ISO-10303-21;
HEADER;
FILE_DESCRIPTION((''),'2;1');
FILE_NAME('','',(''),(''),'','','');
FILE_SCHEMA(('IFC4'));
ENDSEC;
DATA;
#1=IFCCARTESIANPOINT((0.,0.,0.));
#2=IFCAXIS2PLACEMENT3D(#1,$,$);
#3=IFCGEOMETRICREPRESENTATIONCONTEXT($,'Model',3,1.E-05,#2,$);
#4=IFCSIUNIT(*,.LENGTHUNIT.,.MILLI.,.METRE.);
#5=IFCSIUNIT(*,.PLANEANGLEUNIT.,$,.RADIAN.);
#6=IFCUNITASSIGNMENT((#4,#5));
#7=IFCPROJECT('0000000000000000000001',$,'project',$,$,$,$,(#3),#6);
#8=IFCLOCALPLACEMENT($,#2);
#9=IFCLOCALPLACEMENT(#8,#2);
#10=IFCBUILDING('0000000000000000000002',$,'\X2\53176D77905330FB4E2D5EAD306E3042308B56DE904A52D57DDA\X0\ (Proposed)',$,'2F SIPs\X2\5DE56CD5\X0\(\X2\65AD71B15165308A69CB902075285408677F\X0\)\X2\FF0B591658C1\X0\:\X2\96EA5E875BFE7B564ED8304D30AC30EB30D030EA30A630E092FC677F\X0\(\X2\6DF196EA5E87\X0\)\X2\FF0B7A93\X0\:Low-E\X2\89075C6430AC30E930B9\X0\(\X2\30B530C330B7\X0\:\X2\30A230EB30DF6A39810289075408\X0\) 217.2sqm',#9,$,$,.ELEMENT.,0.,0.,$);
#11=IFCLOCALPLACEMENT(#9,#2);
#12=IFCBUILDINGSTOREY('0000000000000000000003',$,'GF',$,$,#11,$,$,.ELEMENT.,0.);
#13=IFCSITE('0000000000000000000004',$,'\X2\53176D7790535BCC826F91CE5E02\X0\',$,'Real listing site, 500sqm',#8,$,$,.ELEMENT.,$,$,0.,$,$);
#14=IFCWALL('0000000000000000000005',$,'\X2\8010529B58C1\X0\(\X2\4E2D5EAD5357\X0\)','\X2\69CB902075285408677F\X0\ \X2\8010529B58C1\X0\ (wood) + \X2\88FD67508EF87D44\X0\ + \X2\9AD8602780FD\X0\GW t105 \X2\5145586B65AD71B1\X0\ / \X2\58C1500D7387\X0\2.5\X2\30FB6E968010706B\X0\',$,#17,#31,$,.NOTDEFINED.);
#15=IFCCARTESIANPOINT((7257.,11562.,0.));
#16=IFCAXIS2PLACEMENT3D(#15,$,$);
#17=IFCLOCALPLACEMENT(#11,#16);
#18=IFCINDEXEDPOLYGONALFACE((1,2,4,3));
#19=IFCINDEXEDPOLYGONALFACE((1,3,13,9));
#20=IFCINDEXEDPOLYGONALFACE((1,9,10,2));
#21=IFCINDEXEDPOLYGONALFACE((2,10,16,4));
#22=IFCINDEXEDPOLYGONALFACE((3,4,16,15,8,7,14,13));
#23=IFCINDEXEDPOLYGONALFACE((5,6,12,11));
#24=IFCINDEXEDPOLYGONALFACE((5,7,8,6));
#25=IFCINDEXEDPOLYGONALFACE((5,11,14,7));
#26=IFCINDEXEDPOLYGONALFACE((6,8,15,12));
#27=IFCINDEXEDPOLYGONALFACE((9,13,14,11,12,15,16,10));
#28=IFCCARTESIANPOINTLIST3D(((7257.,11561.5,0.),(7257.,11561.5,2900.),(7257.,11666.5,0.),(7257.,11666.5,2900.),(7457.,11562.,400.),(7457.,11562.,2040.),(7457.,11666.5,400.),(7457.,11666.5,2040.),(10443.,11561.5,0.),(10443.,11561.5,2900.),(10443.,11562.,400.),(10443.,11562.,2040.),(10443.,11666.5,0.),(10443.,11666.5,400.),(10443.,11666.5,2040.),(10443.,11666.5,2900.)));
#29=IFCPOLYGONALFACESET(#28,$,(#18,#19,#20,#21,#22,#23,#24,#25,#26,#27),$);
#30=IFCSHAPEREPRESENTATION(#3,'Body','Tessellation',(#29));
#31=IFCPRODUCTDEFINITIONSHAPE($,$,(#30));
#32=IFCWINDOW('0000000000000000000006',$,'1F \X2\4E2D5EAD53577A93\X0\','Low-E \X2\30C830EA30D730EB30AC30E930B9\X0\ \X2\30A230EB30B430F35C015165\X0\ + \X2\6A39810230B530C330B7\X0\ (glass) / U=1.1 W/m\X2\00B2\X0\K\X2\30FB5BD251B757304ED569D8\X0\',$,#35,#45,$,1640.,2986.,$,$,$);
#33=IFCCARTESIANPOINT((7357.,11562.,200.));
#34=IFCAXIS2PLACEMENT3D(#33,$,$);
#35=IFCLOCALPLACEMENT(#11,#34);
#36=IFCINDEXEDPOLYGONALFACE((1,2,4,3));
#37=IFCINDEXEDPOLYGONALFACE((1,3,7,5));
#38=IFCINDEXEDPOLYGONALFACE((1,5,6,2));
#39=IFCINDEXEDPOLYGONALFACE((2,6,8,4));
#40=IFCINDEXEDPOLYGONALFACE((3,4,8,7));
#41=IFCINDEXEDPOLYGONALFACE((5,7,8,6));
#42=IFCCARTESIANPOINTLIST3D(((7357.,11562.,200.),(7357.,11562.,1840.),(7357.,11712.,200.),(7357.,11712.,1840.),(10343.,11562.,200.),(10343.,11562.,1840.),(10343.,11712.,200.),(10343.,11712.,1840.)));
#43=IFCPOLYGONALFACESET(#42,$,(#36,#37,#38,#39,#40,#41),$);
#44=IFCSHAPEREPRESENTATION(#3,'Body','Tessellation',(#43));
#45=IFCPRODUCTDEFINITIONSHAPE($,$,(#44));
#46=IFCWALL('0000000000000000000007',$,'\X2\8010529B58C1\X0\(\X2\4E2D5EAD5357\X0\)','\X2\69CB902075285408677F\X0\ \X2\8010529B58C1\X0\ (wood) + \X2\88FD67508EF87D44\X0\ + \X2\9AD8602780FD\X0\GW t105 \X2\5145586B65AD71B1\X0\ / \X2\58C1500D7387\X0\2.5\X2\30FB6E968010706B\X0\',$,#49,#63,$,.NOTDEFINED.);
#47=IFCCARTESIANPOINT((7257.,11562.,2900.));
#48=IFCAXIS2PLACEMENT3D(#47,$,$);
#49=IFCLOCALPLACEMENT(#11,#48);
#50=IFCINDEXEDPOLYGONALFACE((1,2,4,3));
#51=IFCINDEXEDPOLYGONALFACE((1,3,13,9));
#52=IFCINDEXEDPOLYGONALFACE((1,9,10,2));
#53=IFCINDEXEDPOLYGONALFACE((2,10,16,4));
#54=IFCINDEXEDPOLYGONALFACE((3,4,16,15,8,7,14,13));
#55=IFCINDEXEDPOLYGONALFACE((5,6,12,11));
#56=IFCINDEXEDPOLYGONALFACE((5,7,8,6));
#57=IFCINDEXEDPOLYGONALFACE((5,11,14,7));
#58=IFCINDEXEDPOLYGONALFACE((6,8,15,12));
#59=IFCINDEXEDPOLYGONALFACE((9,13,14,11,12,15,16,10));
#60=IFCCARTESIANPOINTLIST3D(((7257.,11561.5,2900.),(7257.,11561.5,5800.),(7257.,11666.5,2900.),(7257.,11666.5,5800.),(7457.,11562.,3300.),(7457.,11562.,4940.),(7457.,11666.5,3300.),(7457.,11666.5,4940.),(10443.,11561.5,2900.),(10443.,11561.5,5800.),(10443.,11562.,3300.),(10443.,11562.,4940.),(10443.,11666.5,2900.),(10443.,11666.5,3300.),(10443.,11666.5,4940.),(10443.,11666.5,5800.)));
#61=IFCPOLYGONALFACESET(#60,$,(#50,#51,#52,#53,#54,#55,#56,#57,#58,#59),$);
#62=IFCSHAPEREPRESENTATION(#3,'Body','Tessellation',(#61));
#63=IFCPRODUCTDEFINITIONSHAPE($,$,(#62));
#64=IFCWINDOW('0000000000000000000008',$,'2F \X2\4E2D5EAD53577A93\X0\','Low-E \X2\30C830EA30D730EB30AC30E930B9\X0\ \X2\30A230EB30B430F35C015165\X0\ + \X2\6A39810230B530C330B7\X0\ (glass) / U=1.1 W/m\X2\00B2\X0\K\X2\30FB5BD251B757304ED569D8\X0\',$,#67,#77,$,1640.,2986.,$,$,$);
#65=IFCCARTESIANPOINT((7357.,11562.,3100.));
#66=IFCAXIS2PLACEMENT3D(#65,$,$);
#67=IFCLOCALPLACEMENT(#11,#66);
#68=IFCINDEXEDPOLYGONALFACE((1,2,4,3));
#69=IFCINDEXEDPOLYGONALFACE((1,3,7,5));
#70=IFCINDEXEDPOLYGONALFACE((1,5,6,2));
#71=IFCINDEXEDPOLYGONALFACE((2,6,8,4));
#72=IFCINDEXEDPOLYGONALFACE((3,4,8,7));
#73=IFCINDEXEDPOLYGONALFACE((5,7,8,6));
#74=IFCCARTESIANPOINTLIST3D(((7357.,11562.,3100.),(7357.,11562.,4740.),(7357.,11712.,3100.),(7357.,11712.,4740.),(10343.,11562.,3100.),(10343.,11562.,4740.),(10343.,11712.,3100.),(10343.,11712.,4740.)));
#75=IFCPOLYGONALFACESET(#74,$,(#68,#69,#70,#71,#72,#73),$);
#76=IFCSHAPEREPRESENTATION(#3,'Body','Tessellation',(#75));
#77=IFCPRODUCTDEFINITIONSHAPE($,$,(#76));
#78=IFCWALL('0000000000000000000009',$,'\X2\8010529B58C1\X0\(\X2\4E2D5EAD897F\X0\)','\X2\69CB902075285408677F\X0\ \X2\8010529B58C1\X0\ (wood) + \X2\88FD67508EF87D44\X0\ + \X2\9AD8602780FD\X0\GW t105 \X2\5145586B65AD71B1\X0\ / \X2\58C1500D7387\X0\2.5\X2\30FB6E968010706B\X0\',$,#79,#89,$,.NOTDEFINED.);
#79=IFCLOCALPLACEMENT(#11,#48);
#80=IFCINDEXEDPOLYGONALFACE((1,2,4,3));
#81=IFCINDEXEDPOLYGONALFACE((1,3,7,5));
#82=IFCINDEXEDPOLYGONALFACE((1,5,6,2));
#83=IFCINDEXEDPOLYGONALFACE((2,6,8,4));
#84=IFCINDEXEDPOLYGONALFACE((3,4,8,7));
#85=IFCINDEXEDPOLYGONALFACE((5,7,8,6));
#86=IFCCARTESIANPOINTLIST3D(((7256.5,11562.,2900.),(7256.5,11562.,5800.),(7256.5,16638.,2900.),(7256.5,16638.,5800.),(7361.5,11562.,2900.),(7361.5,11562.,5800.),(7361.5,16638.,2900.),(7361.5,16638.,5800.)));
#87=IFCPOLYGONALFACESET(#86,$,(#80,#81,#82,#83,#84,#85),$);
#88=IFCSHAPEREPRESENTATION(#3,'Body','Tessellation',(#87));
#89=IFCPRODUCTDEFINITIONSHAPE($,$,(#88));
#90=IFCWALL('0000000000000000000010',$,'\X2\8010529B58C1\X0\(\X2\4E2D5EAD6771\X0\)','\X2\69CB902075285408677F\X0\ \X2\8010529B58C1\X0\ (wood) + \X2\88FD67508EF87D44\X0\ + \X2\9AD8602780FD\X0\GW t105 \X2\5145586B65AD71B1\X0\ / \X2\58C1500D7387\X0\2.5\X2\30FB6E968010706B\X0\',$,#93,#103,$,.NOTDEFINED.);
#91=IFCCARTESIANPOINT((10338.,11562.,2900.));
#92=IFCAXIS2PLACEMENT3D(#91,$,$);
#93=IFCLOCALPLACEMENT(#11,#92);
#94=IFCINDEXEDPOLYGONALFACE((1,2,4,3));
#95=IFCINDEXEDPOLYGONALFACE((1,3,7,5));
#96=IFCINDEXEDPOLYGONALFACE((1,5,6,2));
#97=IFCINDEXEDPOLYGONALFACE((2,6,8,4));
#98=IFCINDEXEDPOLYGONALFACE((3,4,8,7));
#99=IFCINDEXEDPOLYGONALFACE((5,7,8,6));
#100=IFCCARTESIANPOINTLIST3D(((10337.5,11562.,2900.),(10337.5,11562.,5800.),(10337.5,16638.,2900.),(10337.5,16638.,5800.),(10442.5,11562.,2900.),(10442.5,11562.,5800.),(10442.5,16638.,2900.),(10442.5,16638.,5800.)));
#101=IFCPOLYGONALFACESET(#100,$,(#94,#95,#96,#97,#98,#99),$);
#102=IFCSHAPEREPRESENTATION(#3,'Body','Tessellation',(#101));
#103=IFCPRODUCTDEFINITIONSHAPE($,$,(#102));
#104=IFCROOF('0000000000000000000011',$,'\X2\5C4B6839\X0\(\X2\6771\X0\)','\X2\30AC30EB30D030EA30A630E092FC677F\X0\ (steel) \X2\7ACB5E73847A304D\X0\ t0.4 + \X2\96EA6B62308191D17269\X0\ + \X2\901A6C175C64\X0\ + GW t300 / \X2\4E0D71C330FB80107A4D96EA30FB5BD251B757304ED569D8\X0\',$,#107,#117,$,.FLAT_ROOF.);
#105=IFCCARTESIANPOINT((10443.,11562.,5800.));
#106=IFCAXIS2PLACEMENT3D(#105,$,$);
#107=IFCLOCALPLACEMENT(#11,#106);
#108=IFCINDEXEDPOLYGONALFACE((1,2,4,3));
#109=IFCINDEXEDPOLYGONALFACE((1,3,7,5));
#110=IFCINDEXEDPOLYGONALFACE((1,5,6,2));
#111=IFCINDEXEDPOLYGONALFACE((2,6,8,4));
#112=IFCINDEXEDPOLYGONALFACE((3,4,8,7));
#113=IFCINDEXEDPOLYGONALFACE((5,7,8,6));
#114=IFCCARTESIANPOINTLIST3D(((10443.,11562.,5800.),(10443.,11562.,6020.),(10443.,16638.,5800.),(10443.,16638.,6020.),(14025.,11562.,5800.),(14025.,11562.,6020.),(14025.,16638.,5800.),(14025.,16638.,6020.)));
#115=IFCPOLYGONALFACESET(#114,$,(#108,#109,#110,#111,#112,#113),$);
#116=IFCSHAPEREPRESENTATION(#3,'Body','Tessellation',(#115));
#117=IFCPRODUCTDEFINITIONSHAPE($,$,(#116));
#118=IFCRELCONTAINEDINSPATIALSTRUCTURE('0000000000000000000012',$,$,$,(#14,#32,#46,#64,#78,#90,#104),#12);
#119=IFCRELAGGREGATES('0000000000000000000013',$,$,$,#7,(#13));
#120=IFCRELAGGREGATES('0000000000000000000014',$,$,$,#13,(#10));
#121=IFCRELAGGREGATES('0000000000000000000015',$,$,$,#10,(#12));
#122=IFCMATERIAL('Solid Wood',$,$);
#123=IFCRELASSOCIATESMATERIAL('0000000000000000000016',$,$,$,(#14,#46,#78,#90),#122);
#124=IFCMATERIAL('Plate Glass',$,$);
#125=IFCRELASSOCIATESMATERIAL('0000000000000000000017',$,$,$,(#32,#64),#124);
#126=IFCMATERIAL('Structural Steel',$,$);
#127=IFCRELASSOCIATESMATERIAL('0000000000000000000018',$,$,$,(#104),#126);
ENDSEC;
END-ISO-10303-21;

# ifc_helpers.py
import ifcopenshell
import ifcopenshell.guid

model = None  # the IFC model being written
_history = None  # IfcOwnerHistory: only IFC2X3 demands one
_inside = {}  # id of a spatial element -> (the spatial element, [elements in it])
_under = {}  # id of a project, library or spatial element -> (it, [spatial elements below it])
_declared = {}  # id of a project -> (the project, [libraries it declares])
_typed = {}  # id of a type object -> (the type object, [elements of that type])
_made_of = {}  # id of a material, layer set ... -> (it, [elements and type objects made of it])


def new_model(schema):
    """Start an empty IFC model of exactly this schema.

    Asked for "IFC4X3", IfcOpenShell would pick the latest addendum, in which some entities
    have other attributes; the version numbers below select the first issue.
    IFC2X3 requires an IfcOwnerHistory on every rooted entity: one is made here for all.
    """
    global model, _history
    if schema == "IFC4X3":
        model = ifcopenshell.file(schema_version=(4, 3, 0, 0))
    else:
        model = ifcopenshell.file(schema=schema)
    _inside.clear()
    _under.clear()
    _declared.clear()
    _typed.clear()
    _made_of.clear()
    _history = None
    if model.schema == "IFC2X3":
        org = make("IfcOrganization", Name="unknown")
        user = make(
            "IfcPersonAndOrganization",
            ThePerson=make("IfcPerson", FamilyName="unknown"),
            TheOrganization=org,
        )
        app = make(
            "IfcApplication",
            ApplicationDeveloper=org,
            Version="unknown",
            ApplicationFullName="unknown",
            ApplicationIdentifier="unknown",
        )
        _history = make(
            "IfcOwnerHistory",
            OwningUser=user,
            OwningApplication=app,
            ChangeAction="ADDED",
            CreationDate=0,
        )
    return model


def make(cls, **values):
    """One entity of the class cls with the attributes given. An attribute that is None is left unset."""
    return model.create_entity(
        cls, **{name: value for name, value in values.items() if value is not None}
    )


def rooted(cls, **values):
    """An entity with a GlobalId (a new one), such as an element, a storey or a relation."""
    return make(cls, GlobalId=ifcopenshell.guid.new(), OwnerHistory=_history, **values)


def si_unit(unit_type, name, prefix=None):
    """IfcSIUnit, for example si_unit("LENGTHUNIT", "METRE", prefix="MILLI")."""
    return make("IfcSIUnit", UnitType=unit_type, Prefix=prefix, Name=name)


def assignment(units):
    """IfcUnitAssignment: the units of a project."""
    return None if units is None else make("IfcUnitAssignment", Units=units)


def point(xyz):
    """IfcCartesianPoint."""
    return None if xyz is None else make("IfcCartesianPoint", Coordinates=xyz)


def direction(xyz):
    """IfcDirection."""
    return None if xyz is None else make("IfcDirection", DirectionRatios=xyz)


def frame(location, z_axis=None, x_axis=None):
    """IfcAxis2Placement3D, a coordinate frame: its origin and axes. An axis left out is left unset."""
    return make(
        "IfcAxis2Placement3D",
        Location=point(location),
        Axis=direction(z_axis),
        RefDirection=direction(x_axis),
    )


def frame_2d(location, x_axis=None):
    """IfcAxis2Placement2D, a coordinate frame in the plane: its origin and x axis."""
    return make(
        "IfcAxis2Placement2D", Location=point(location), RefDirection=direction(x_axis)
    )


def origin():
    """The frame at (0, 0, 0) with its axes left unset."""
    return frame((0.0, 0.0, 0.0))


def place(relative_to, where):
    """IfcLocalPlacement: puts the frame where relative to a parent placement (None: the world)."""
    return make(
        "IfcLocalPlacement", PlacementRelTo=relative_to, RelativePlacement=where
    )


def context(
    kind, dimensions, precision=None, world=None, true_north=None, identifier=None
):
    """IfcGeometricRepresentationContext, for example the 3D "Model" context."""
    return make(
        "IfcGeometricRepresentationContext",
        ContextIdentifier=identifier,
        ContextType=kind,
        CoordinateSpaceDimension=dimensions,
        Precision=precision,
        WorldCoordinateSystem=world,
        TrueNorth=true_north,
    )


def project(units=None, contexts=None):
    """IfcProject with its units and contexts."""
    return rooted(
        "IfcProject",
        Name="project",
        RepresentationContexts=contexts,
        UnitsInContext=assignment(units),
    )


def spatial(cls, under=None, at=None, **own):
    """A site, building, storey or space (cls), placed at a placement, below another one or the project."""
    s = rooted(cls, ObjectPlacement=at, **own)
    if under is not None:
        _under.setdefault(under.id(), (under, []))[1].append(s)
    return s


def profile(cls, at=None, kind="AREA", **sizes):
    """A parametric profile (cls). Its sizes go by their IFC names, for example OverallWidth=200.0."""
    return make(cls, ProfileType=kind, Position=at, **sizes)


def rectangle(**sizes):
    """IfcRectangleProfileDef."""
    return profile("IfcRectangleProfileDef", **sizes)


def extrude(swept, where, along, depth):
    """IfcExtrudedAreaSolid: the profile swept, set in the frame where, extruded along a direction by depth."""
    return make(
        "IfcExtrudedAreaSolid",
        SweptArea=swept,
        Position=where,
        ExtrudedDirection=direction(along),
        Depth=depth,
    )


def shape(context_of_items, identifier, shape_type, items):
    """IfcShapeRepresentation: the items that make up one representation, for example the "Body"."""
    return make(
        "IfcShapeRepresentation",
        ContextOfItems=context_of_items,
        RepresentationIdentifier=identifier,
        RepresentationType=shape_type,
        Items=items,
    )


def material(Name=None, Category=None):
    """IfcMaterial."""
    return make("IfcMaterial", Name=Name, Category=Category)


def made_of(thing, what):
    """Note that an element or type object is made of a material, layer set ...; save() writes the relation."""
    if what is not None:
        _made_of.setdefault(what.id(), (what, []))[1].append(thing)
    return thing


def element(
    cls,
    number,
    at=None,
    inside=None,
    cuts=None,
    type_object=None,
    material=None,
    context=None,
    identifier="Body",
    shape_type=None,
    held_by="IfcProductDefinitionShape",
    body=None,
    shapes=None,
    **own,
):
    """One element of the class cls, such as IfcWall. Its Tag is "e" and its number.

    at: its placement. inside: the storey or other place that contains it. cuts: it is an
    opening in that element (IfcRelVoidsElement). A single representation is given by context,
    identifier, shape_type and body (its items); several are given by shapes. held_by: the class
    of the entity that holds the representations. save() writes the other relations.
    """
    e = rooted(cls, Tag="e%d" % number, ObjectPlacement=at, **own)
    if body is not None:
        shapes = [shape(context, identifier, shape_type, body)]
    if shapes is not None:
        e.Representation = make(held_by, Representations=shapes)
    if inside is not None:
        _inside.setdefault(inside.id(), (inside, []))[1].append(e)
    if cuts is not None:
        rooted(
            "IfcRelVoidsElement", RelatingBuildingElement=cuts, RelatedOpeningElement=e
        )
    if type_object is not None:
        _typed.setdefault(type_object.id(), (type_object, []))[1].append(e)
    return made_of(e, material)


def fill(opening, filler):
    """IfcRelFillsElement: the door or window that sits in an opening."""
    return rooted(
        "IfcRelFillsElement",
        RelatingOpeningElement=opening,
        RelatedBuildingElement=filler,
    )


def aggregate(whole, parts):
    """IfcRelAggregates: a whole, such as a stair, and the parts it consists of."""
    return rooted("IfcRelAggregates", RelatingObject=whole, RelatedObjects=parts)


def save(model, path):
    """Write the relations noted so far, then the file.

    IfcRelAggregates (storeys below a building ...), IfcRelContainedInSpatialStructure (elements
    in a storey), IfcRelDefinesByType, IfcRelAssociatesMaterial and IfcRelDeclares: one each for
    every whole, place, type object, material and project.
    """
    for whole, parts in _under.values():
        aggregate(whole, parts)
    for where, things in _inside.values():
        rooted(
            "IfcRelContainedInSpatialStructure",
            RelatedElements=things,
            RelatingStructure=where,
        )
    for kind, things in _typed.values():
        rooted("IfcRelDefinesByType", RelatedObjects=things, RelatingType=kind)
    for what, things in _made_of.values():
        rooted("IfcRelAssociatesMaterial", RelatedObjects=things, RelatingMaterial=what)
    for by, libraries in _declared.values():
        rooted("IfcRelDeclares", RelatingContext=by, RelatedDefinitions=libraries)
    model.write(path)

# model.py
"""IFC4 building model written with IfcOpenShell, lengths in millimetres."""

from ifc_helpers import new_model, si_unit, frame, frame_2d, origin, place, context, project, spatial, rectangle, extrude, material, element, fill, save


model = new_model("IFC4")

# Units and contexts
model_context = context("Model", 3, precision=1e-05, world=origin())
ifc_project = project(units=[si_unit("LENGTHUNIT", "METRE", prefix="MILLI"), si_unit("PLANEANGLEUNIT", "RADIAN")], contexts=[model_context])

# Site, building, storey
site_placement = place(None, origin())
site = spatial("IfcSite", under=ifc_project, at=site_placement, Name="北海道富良野市", ObjectType="Real listing site, 500sqm", CompositionType="ELEMENT", RefElevation=0.0)
building_placement = place(site_placement, origin())
building = spatial("IfcBuilding", under=site, at=building_placement, Name="北海道・中庭のある回遊動線 (Proposed)", ObjectType="2F SIPs工法(断熱入り構造用合板)＋外壁:雪庇対策付きガルバリウム鋼板(深雪庇)＋窓:Low-E複層ガラス(サッシ:アルミ樹脂複合) 217.2sqm", CompositionType="ELEMENT", ElevationOfRefHeight=0.0, ElevationOfTerrain=0.0)
storey_placement = place(building_placement, origin())
storey = spatial("IfcBuildingStorey", under=building, at=storey_placement, Name="GF", CompositionType="ELEMENT", Elevation=0.0)

# Shared definitions
ifc_material_1 = material(Name="Solid Wood")

# Wall, opening, window
wall_1_placement = place(storey_placement, frame((7257.0, 11562.0, 0.0)))
wall_1 = element("IfcWall", 1, at=wall_1_placement, inside=storey, material=ifc_material_1, Name="耐力壁(中庭南)", Description="構造用合板 耐力壁 (wood) + 製材軸組 + 高性能GW t105 充填断熱 / 壁倍率2.5・準耐火", PredefinedType="NOTDEFINED", context=model_context, shape_type="SweptSolid", body=[
    extrude(rectangle(XDim=3186.0, YDim=105.0, at=frame_2d((1593.0, 52.0))), frame((7257.0, 11562.0, 0.0)), (0.0, 0.0, 1.0), 2900.0),
])
opening_1_placement = place(storey_placement, frame((7357.0, 11562.0, 200.0)))
opening_1 = element("IfcOpeningElement", 2, at=opening_1_placement, cuts=wall_1, PredefinedType="NOTDEFINED", context=model_context, shape_type="SweptSolid", body=[
    extrude(rectangle(XDim=2986.0, YDim=150.0, at=frame_2d((1493.0, 75.0))), frame((7357.0, 11562.0, 200.0)), (0.0, 0.0, 1.0), 1640.0),
])
ifc_material_2 = material(Name="Plate Glass")
window_1_placement = place(storey_placement, frame((7357.0, 11562.0, 200.0)))
window_1 = element("IfcWindow", 3, at=window_1_placement, inside=storey, material=ifc_material_2, Name="1F 中庭南窓", Description="Low-E トリプルガラス アルゴン封入 + 樹脂サッシ (glass) / U=1.1 W/m²K・寒冷地仕様", OverallHeight=1640.0, OverallWidth=2986.0, context=model_context, shape_type="SweptSolid", body=[
    extrude(rectangle(XDim=2986.0, YDim=150.0, at=frame_2d((1493.0, 75.0))), frame((7357.0, 11562.0, 200.0)), (0.0, 0.0, 1.0), 1640.0),
])
fill(opening_1, window_1)

# Wall, opening, window
wall_2_placement = place(storey_placement, frame((7257.0, 11562.0, 2900.0)))
wall_2 = element("IfcWall", 4, at=wall_2_placement, inside=storey, material=ifc_material_1, Name="耐力壁(中庭南)", Description="構造用合板 耐力壁 (wood) + 製材軸組 + 高性能GW t105 充填断熱 / 壁倍率2.5・準耐火", PredefinedType="NOTDEFINED", context=model_context, shape_type="SweptSolid", body=[
    extrude(rectangle(XDim=3186.0, YDim=105.0, at=frame_2d((1593.0, 52.0))), frame((7257.0, 11562.0, 2900.0)), (0.0, 0.0, 1.0), 2900.0),
])
opening_2_placement = place(storey_placement, frame((7357.0, 11562.0, 3100.0)))
opening_2 = element("IfcOpeningElement", 5, at=opening_2_placement, cuts=wall_2, PredefinedType="NOTDEFINED", context=model_context, shape_type="SweptSolid", body=[
    extrude(rectangle(XDim=2986.0, YDim=150.0, at=frame_2d((1493.0, 75.0))), frame((7357.0, 11562.0, 3100.0)), (0.0, 0.0, 1.0), 1640.0),
])
window_2_placement = place(storey_placement, frame((7357.0, 11562.0, 3100.0)))
window_2 = element("IfcWindow", 6, at=window_2_placement, inside=storey, material=ifc_material_2, Name="2F 中庭南窓", Description="Low-E トリプルガラス アルゴン封入 + 樹脂サッシ (glass) / U=1.1 W/m²K・寒冷地仕様", OverallHeight=1640.0, OverallWidth=2986.0, context=model_context, shape_type="SweptSolid", body=[
    extrude(rectangle(XDim=2986.0, YDim=150.0, at=frame_2d((1493.0, 75.0))), frame((7357.0, 11562.0, 3100.0)), (0.0, 0.0, 1.0), 1640.0),
])
fill(opening_2, window_2)

# Walls
wall_3_placement = place(storey_placement, frame((7257.0, 11562.0, 2900.0)))
element("IfcWall", 7, at=wall_3_placement, inside=storey, material=ifc_material_1, Name="耐力壁(中庭西)", Description="構造用合板 耐力壁 (wood) + 製材軸組 + 高性能GW t105 充填断熱 / 壁倍率2.5・準耐火", PredefinedType="NOTDEFINED", context=model_context, shape_type="SweptSolid", body=[
    extrude(rectangle(XDim=105.0, YDim=5076.0, at=frame_2d((52.0, 2538.0))), frame((7257.0, 11562.0, 2900.0)), (0.0, 0.0, 1.0), 2900.0),
])
wall_4_placement = place(storey_placement, frame((10338.0, 11562.0, 2900.0)))
element("IfcWall", 8, at=wall_4_placement, inside=storey, material=ifc_material_1, Name="耐力壁(中庭東)", Description="構造用合板 耐力壁 (wood) + 製材軸組 + 高性能GW t105 充填断熱 / 壁倍率2.5・準耐火", PredefinedType="NOTDEFINED", context=model_context, shape_type="SweptSolid", body=[
    extrude(rectangle(XDim=105.0, YDim=5076.0, at=frame_2d((52.0, 2538.0))), frame((10338.0, 11562.0, 2900.0)), (0.0, 0.0, 1.0), 2900.0),
])

# Roof
ifc_material_3 = material(Name="Structural Steel")
for number, where, name in (
    (9, (10443.0, 11562.0, 5800.0), "屋根(東)"),
):
    element("IfcRoof", number, at=place(storey_placement, frame(where)), inside=storey, material=ifc_material_3, Name=name, Description="ガルバリウム鋼板 (steel) 立平葺き t0.4 + 雪止め金物 + 通気層 + GW t300 / 不燃・耐積雪・寒冷地仕様", PredefinedType="FLAT_ROOF", context=model_context, shape_type="SweptSolid", body=[
        extrude(rectangle(XDim=3582.0, YDim=5076.0, at=frame_2d((1791.0, 2538.0))), frame((10443.0, 11562.0, 5800.0)), (0.0, 0.0, 1.0), 220.0),
    ])

save(model, "model.ifc")
